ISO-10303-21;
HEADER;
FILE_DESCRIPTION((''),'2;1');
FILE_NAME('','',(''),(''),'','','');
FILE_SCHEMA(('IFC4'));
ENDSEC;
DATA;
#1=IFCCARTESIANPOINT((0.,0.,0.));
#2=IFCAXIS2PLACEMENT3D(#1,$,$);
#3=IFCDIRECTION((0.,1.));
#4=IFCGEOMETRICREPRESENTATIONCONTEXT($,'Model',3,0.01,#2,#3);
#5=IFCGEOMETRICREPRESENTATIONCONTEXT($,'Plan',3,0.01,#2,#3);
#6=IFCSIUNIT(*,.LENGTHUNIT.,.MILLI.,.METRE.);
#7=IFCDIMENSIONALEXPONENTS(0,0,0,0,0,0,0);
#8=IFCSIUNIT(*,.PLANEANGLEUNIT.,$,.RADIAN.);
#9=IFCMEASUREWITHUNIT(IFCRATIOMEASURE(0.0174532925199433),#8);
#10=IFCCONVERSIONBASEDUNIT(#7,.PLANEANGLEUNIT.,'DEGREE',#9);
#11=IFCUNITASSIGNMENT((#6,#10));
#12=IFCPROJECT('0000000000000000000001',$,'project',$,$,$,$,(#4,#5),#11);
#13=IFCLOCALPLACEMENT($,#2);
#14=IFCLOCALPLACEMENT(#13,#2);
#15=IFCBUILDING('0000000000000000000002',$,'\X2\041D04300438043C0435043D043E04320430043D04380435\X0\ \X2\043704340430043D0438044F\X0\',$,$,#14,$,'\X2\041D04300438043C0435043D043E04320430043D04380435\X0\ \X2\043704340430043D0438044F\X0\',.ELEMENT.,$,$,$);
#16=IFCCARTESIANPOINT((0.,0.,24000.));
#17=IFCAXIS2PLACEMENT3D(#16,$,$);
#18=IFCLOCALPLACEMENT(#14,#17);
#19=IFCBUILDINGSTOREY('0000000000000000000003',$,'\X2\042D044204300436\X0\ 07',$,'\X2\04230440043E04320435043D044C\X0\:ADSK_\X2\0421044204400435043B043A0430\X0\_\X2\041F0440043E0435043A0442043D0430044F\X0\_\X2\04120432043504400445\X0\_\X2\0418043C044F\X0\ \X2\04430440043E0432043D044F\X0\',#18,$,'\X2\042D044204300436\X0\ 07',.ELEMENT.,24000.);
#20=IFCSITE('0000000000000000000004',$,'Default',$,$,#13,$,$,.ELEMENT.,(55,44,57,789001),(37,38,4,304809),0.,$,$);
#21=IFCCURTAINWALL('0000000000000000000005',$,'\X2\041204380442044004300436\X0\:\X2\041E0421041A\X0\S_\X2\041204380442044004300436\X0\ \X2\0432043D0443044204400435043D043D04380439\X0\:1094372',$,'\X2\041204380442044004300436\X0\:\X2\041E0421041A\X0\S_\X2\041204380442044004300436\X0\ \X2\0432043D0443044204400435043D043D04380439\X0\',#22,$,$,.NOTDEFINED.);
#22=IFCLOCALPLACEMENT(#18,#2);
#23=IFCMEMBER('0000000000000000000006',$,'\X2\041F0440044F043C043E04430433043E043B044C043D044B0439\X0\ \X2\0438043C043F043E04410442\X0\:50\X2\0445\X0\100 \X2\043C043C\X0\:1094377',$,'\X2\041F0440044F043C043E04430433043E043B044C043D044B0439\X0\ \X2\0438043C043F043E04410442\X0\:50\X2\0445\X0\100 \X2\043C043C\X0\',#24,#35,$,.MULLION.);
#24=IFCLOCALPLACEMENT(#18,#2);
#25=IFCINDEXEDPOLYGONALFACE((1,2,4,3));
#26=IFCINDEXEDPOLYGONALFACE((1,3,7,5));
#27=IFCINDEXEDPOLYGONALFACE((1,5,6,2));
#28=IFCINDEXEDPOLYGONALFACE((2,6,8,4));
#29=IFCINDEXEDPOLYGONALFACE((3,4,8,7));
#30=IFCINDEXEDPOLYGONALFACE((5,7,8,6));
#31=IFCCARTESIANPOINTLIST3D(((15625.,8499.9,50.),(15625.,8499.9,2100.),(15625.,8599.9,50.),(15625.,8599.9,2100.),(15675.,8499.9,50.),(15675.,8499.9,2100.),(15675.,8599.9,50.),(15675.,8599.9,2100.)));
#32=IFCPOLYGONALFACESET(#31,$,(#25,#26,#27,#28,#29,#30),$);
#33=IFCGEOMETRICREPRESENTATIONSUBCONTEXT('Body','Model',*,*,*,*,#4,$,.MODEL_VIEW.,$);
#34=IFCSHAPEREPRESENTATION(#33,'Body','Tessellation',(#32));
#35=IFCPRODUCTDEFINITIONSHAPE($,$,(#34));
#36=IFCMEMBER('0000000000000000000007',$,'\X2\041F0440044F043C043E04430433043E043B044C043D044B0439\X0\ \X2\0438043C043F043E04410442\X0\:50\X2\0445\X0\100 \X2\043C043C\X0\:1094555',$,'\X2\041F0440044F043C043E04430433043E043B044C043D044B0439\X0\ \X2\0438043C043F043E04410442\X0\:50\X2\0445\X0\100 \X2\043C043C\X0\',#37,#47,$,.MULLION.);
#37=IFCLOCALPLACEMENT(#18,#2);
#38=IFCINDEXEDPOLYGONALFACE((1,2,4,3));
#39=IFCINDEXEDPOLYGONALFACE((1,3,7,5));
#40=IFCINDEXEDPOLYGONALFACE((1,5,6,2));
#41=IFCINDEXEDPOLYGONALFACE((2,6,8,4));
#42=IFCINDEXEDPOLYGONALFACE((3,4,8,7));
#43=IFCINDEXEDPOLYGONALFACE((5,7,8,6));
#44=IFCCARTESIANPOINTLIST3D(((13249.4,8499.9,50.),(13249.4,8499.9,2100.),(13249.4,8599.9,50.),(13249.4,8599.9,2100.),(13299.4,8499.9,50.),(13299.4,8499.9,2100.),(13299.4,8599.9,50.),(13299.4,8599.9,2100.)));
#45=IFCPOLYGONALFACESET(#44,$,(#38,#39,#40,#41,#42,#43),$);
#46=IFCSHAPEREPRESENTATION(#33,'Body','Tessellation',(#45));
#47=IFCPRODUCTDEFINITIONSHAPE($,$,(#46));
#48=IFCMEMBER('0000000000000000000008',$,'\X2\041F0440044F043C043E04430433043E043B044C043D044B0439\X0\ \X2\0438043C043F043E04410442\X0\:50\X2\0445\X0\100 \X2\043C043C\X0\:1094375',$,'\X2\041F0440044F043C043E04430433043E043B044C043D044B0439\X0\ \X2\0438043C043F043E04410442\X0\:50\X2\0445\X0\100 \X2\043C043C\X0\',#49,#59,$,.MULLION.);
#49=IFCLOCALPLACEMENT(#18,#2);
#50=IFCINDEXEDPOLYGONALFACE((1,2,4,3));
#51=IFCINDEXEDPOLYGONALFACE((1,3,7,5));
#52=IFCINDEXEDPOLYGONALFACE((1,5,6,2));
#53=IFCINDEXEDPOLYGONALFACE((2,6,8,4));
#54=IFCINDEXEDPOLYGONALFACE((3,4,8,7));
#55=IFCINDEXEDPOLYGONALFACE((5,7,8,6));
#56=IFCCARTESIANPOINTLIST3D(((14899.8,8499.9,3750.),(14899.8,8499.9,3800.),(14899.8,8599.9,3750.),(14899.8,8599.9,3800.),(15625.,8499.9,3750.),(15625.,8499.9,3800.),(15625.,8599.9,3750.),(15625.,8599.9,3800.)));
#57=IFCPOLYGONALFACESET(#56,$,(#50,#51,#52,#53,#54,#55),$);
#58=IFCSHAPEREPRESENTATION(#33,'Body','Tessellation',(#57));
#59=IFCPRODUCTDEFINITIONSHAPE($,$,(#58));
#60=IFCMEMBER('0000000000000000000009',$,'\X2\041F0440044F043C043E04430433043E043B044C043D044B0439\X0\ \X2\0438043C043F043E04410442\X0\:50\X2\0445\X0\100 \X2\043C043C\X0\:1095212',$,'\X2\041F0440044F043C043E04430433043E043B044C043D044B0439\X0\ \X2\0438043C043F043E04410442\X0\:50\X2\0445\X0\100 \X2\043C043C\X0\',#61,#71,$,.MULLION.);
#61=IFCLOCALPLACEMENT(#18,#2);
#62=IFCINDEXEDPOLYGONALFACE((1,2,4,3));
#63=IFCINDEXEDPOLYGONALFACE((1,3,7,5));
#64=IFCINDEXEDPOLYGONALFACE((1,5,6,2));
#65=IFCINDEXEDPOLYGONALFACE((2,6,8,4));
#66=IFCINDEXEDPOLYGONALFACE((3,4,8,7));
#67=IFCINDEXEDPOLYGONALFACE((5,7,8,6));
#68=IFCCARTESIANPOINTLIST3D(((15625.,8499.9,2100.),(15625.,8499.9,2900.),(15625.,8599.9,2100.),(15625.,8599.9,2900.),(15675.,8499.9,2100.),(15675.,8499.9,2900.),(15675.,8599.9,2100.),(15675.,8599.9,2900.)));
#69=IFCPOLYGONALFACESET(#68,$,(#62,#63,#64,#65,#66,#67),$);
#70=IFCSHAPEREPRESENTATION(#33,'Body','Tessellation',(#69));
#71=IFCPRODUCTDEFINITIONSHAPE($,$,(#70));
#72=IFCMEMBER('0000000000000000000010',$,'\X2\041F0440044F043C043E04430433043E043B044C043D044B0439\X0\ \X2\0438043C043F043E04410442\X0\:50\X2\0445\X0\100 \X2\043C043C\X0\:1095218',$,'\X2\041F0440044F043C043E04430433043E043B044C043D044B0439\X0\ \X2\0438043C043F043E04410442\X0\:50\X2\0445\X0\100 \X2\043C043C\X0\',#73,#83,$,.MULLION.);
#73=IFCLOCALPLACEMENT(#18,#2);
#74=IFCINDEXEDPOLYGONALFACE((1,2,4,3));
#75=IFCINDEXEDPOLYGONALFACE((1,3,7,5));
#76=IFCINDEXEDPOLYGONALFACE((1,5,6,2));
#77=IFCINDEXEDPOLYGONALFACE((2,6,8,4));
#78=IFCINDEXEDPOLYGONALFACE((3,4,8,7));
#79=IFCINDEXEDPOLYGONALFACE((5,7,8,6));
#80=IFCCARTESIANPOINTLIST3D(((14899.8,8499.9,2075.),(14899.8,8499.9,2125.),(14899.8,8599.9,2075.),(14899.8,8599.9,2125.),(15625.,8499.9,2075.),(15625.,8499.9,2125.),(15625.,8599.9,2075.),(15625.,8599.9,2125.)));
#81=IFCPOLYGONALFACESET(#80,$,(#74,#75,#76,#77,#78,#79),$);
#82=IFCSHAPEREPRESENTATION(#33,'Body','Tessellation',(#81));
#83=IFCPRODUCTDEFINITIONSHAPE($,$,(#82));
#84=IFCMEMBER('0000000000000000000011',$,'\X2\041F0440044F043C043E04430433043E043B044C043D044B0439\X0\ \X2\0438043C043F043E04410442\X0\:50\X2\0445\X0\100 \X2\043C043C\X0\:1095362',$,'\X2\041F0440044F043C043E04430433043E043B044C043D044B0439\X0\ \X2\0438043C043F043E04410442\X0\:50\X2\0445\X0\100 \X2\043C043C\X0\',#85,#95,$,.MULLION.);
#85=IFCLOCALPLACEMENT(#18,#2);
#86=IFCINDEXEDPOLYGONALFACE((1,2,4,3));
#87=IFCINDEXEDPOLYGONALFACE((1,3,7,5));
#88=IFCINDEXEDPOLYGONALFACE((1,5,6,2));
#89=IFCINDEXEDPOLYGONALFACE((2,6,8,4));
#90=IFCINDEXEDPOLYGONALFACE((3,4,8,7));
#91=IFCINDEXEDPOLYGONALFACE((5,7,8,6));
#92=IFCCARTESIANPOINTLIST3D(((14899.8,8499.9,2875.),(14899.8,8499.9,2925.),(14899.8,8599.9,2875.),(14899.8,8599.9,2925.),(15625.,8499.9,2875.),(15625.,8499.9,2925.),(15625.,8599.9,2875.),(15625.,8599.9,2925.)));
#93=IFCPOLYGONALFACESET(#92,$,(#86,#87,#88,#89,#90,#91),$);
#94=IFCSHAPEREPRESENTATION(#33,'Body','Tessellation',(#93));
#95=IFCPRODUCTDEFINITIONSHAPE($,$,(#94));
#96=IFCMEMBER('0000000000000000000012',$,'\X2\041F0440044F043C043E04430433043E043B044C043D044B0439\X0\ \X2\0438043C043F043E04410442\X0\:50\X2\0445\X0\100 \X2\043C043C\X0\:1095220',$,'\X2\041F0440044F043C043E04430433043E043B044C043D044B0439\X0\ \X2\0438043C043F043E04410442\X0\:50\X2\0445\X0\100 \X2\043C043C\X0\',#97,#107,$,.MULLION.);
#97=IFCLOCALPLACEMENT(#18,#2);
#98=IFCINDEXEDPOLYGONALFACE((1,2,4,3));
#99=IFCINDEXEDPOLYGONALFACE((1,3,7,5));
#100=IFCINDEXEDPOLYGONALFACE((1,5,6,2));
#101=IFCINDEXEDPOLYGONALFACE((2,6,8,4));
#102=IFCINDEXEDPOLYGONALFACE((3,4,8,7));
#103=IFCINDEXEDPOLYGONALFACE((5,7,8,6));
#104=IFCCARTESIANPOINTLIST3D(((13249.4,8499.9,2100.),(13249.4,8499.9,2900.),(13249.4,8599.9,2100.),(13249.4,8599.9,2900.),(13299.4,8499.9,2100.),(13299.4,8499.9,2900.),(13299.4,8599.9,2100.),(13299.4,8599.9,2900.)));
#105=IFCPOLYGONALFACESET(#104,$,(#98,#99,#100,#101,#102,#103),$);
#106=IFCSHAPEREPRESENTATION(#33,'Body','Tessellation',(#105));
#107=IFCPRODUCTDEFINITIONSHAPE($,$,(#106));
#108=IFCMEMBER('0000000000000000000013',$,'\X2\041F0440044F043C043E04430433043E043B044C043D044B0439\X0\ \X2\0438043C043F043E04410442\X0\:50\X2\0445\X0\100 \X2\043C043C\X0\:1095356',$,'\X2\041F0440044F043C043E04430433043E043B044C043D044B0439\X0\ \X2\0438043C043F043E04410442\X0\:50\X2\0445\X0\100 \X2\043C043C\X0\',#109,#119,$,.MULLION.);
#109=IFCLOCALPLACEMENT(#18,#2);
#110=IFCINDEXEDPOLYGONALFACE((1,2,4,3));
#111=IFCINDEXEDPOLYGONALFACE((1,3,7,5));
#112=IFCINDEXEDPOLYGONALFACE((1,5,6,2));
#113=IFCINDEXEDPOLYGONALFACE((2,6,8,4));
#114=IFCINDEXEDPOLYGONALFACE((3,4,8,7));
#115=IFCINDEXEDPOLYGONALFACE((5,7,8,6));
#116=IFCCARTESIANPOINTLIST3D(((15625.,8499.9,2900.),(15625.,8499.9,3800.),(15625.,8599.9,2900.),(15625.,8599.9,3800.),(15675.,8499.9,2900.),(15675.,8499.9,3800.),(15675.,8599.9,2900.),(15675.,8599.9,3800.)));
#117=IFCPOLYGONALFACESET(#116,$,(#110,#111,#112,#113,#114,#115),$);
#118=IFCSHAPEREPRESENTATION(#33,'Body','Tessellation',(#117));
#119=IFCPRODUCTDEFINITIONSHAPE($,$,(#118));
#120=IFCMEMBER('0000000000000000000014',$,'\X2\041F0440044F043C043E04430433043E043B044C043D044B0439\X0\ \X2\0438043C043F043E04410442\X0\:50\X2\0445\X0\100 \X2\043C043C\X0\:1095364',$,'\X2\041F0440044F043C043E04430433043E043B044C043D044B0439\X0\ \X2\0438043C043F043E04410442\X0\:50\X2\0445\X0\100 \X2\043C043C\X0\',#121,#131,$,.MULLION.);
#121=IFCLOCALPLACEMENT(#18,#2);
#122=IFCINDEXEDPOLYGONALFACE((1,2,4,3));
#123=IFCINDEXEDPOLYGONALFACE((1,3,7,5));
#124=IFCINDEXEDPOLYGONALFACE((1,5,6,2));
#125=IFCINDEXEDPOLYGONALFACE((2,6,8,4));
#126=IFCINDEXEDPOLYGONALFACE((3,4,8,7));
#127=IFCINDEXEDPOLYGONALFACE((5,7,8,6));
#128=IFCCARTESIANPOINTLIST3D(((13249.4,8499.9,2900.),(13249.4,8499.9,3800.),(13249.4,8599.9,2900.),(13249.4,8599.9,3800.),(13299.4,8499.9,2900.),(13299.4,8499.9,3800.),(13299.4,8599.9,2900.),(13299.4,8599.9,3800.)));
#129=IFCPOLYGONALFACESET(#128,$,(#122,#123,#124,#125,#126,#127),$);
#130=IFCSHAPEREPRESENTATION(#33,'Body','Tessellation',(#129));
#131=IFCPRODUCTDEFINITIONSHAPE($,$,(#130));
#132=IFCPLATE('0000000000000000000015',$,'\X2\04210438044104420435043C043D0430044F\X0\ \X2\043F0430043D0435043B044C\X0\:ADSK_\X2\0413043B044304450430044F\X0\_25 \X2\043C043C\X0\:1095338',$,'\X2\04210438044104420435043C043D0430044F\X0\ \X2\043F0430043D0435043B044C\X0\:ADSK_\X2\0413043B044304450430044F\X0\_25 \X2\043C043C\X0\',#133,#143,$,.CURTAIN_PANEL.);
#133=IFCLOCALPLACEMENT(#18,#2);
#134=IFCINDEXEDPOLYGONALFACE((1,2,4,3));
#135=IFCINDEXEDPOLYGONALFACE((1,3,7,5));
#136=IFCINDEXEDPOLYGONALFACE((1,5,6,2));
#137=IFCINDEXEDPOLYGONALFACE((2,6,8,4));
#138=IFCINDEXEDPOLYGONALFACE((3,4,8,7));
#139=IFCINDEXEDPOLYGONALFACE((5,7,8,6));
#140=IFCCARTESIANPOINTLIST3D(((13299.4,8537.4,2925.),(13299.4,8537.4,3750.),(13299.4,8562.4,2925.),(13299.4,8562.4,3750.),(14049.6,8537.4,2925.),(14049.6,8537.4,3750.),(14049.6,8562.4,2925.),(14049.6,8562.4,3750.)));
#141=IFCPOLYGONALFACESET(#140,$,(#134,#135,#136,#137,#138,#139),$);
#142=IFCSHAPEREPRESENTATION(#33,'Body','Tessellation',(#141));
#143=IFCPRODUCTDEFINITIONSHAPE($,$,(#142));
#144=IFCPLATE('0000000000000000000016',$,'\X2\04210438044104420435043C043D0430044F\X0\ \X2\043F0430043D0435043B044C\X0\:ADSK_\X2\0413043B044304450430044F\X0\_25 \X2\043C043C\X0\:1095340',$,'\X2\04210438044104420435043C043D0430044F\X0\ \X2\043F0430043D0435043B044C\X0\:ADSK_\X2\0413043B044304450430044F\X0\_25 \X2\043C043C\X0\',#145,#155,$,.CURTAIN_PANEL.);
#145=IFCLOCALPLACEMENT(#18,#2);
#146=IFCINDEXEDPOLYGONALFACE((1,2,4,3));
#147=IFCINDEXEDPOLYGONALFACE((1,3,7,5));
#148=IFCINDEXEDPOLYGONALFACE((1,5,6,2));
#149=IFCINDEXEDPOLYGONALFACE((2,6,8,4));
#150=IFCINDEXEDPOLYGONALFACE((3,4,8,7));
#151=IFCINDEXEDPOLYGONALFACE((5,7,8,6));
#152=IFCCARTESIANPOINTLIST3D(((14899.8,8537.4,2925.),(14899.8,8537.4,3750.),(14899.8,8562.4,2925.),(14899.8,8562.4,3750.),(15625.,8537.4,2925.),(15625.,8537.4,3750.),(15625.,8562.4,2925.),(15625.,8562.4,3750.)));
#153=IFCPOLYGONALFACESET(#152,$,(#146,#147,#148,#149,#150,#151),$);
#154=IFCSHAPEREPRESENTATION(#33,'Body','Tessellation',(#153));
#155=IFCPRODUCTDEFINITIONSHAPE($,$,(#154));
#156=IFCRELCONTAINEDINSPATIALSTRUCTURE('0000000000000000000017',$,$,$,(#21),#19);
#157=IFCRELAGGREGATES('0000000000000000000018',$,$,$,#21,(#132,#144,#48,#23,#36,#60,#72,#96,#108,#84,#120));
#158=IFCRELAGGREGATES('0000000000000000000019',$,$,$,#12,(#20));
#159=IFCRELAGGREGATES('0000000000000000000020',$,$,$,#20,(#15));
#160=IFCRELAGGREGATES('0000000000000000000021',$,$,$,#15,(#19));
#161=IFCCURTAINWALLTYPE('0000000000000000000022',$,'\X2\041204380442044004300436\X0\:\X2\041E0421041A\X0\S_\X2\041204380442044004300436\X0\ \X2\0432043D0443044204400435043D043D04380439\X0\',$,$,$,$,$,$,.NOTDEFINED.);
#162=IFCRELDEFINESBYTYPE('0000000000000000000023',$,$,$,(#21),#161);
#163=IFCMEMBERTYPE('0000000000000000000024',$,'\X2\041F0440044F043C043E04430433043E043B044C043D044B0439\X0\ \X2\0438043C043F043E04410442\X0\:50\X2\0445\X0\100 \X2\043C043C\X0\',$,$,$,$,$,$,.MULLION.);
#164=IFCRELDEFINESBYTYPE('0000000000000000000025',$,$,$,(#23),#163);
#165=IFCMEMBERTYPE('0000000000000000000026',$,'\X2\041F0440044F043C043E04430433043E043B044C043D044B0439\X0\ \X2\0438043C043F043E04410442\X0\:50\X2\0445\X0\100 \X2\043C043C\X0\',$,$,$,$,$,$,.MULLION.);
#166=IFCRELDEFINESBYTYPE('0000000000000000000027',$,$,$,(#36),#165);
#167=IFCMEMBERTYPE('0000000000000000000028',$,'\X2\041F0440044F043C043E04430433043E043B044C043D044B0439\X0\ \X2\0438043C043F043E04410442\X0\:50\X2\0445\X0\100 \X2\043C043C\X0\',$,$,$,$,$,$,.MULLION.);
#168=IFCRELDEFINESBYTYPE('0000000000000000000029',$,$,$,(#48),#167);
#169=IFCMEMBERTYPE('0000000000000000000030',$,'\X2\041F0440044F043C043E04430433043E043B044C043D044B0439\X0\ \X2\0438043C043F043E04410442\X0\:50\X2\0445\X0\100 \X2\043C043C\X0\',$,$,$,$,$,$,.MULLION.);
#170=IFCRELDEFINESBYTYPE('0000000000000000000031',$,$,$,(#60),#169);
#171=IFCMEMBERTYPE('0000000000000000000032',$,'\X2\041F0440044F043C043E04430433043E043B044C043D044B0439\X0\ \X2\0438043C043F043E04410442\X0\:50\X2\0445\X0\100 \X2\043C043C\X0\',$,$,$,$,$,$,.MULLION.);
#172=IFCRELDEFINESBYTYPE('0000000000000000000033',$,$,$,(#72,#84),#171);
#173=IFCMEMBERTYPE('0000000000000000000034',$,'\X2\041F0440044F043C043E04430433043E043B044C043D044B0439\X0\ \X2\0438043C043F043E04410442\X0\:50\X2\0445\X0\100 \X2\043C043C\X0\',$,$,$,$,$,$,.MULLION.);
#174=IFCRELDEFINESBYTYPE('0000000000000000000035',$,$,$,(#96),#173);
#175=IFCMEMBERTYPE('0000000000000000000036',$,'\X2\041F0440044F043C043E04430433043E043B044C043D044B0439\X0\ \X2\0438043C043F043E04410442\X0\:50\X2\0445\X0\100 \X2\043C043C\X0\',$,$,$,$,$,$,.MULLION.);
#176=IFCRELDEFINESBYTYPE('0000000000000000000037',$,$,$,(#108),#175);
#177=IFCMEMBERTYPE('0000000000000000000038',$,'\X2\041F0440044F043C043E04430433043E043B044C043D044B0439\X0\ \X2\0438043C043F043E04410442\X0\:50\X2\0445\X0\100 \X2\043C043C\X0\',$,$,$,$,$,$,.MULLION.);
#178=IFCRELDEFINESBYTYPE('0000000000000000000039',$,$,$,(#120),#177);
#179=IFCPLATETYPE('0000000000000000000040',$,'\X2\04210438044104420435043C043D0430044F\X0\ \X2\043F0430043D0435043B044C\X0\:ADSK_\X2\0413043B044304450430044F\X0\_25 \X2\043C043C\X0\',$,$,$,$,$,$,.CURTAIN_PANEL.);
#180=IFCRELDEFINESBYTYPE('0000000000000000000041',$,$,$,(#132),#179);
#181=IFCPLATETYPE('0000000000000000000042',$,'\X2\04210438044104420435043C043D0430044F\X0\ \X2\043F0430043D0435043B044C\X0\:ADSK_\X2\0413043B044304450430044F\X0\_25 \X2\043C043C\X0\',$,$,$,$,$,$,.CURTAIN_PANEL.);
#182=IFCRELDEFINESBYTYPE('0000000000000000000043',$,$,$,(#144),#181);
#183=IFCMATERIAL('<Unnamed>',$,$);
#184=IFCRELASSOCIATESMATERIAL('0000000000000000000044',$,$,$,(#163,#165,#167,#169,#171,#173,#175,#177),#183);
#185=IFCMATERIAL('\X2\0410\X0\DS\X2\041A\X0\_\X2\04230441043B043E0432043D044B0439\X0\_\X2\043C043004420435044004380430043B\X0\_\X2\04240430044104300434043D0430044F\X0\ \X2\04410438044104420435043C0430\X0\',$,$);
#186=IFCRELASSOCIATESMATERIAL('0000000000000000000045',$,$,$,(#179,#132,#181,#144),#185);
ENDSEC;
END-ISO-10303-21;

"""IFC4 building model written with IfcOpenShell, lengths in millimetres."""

from ifc_helpers import new_model, entity, si_unit, converted_unit, direction, frame, origin, place, context, subcontext, project, spatial, indexed_curve, outline, extrude, source, transform, mapped, material, type_object, type_shapes, element, aggregate, save


model = new_model("IFC4")

# Units and contexts
model_context = context("Model", 3, precision=0.01, world=origin(), true_north=direction((0.0, 1.0)))
plan_context = context("Plan", 3, precision=0.01, world=origin(), true_north=direction((0.0, 1.0)))
body_context = subcontext(model_context, "Body", "Model", "MODEL_VIEW")
ifc_project = project(units=[si_unit("LENGTHUNIT", "METRE", prefix="MILLI"), converted_unit("PLANEANGLEUNIT", "DEGREE", entity("IfcRatioMeasure", 0.0174532925199433), si_unit("PLANEANGLEUNIT", "RADIAN"), dimensions=[0, 0, 0, 0, 0, 0, 0])], contexts=[model_context, plan_context])

# Site, building, storey
site_placement = place(None, frame((0.0, 0.0, 0.0)))
site = spatial("IfcSite", under=ifc_project, at=site_placement, Name="Default", CompositionType="ELEMENT", RefLatitude=(55, 44, 57, 789001), RefLongitude=(37, 38, 4, 304809), RefElevation=0.0)
building_placement = place(site_placement, origin())
building = spatial("IfcBuilding", under=site, at=building_placement, Name="Наименование здания", LongName="Наименование здания", CompositionType="ELEMENT")
storey_placement = place(building_placement, frame((0.0, 0.0, 24000.0)))
storey = spatial("IfcBuildingStorey", under=building, at=storey_placement, Name="Этаж 07", ObjectType="Уровень:ADSK_Стрелка_Проектная_Вверх_Имя уровня", LongName="Этаж 07", CompositionType="ELEMENT", Elevation=24000.0)

# Curtain wall, members, plates
curtain_wall_type = type_object("IfcCurtainWallType", Name="Витраж:ОСКS_Витраж внутренний", PredefinedType="NOTDEFINED")
curtain_wall_placement = place(storey_placement, frame((0.0, 0.0, -24000.0)))
curtain_wall = element("IfcCurtainWall", 1, at=curtain_wall_placement, inside=storey, type_object=curtain_wall_type, Name="Витраж:ОСКS_Витраж внутренний:1094372", ObjectType="Витраж:ОСКS_Витраж внутренний", PredefinedType="NOTDEFINED")
ifc_material_1 = material(Name="<Unnamed>")
member_type_1 = type_object("IfcMemberType", Name="Прямоугольный импост:50х100 мм", PredefinedType="MULLION", material=ifc_material_1)
shared_shape_1 = source(origin(), body_context, "Body", "SweptSolid", [
    extrude(outline(indexed_curve([(-50.0, -25.0), (50.0, -25.0), (50.0, 25.0), (-50.0, 25.0), (-50.0, -25.0)], self_intersect=False)), frame((-25.0, 0.0, -2050.0), z_axis=(0.0, 0.0, 1.0), x_axis=(0.0, -1.0, 0.0)), (0.0, 0.0, 1.0), 2050.0),
])
type_shapes(member_type_1, [shared_shape_1])
member_1_placement = place(storey_placement, frame((15675.0, 8549.9, 50.0), z_axis=(0.0, 0.0, -1.0), x_axis=(1.0, 0.0, 0.0)))
member_1 = element("IfcMember", 2, at=member_1_placement, type_object=member_type_1, Name="Прямоугольный импост:50х100 мм:1094377", ObjectType="Прямоугольный импост:50х100 мм", PredefinedType="MULLION", context=body_context, shape_type="MappedRepresentation", body=[
    mapped(shared_shape_1, transform((0.0, 0.0, 0.0), scale=1.0)),
])
member_type_2 = type_object("IfcMemberType", Name="Прямоугольный импост:50х100 мм", PredefinedType="MULLION", material=ifc_material_1)
shared_shape_2 = source(origin(), body_context, "Body", "SweptSolid", [
    extrude(outline(indexed_curve([(-50.0, -25.0), (50.0, -25.0), (50.0, 25.0), (-50.0, 25.0), (-50.0, -25.0)], self_intersect=False)), frame((0.0, 0.0, -2050.0), z_axis=(0.0, 0.0, 1.0), x_axis=(0.0, -1.0, 0.0)), (0.0, 0.0, 1.0), 2050.0),
])
type_shapes(member_type_2, [shared_shape_2])
member_2_placement = place(storey_placement, frame((13274.4, 8549.9, 50.0), z_axis=(0.0, 0.0, -1.0), x_axis=(1.0, 0.0, 0.0)))
member_2 = element("IfcMember", 3, at=member_2_placement, type_object=member_type_2, Name="Прямоугольный импост:50х100 мм:1094555", ObjectType="Прямоугольный импост:50х100 мм", PredefinedType="MULLION", context=body_context, shape_type="MappedRepresentation", body=[
    mapped(shared_shape_2, transform((0.0, 0.0, 0.0), scale=1.0)),
])
member_type_3 = type_object("IfcMemberType", Name="Прямоугольный импост:50х100 мм", PredefinedType="MULLION", material=ifc_material_1)
shared_shape_3 = source(origin(), body_context, "Body", "SweptSolid", [
    extrude(outline(indexed_curve([(-50.0, -25.0), (50.0, -25.0), (50.0, 25.0), (-50.0, 25.0), (-50.0, -25.0)], self_intersect=False)), frame((-25.0, 0.0, -725.2), z_axis=(0.0, 0.0, 1.0), x_axis=(0.0, -1.0, 0.0)), (0.0, 0.0, 1.0), 725.2),
])
type_shapes(member_type_3, [shared_shape_3])
member_3_placement = place(storey_placement, frame((15625.0, 8549.9, 3800.0), z_axis=(1.0, 0.0, 0.0), x_axis=(0.0, 0.0, 1.0)))
member_3 = element("IfcMember", 4, at=member_3_placement, type_object=member_type_3, Name="Прямоугольный импост:50х100 мм:1094375", ObjectType="Прямоугольный импост:50х100 мм", PredefinedType="MULLION", context=body_context, shape_type="MappedRepresentation", body=[
    mapped(shared_shape_3, transform((0.0, 0.0, 0.0), scale=1.0)),
])
member_type_4 = type_object("IfcMemberType", Name="Прямоугольный импост:50х100 мм", PredefinedType="MULLION", material=ifc_material_1)
shared_shape_4 = source(origin(), body_context, "Body", "SweptSolid", [
    extrude(outline(indexed_curve([(-50.0, -25.0), (50.0, -25.0), (50.0, 25.0), (-50.0, 25.0), (-50.0, -25.0)], self_intersect=False)), frame((-25.0, 0.0, -800.0), z_axis=(0.0, 0.0, 1.0), x_axis=(0.0, -1.0, 0.0)), (0.0, 0.0, 1.0), 800.0),
])
type_shapes(member_type_4, [shared_shape_4])
member_4_placement = place(storey_placement, frame((15675.0, 8549.9, 2100.0), z_axis=(0.0, 0.0, -1.0), x_axis=(1.0, 0.0, 0.0)))
member_4 = element("IfcMember", 5, at=member_4_placement, type_object=member_type_4, Name="Прямоугольный импост:50х100 мм:1095212", ObjectType="Прямоугольный импост:50х100 мм", PredefinedType="MULLION", context=body_context, shape_type="MappedRepresentation", body=[
    mapped(shared_shape_4, transform((0.0, 0.0, 0.0), scale=1.0)),
])
member_type_5 = type_object("IfcMemberType", Name="Прямоугольный импост:50х100 мм", PredefinedType="MULLION", material=ifc_material_1)
shared_shape_5 = source(origin(), body_context, "Body", "SweptSolid", [
    extrude(outline(indexed_curve([(-50.0, -25.0), (50.0, -25.0), (50.0, 25.0), (-50.0, 25.0), (-50.0, -25.0)], self_intersect=False)), frame((0.0, 0.0, -725.2), z_axis=(0.0, 0.0, 1.0), x_axis=(0.0, -1.0, 0.0)), (0.0, 0.0, 1.0), 725.2),
])
type_shapes(member_type_5, [shared_shape_5])
member_5_placement = place(storey_placement, frame((15625.0, 8549.9, 2100.0), z_axis=(1.0, 0.0, 0.0), x_axis=(0.0, 0.0, 1.0)))
member_5 = element("IfcMember", 6, at=member_5_placement, type_object=member_type_5, Name="Прямоугольный импост:50х100 мм:1095218", ObjectType="Прямоугольный импост:50х100 мм", PredefinedType="MULLION", context=body_context, shape_type="MappedRepresentation", body=[
    mapped(shared_shape_5, transform((0.0, 0.0, 0.0), scale=1.0)),
])
member_6_placement = place(storey_placement, frame((15625.0, 8549.9, 2900.0), z_axis=(1.0, 0.0, 0.0), x_axis=(0.0, 0.0, 1.0)))
member_6 = element("IfcMember", 7, at=member_6_placement, type_object=member_type_5, Name="Прямоугольный импост:50х100 мм:1095362", ObjectType="Прямоугольный импост:50х100 мм", PredefinedType="MULLION", context=body_context, shape_type="MappedRepresentation", body=[
    mapped(shared_shape_5, transform((0.0, 0.0, 0.0), scale=1.0)),
])
member_type_6 = type_object("IfcMemberType", Name="Прямоугольный импост:50х100 мм", PredefinedType="MULLION", material=ifc_material_1)
shared_shape_6 = source(origin(), body_context, "Body", "SweptSolid", [
    extrude(outline(indexed_curve([(-50.0, -25.0), (50.0, -25.0), (50.0, 25.0), (-50.0, 25.0), (-50.0, -25.0)], self_intersect=False)), frame((0.0, 0.0, -800.0), z_axis=(0.0, 0.0, 1.0), x_axis=(0.0, -1.0, 0.0)), (0.0, 0.0, 1.0), 800.0),
])
type_shapes(member_type_6, [shared_shape_6])
member_7_placement = place(storey_placement, frame((13274.4, 8549.9, 2100.0), z_axis=(0.0, 0.0, -1.0), x_axis=(1.0, 0.0, 0.0)))
member_7 = element("IfcMember", 8, at=member_7_placement, type_object=member_type_6, Name="Прямоугольный импост:50х100 мм:1095220", ObjectType="Прямоугольный импост:50х100 мм", PredefinedType="MULLION", context=body_context, shape_type="MappedRepresentation", body=[
    mapped(shared_shape_6, transform((0.0, 0.0, 0.0), scale=1.0)),
])
member_type_7 = type_object("IfcMemberType", Name="Прямоугольный импост:50х100 мм", PredefinedType="MULLION", material=ifc_material_1)
shared_shape_7 = source(origin(), body_context, "Body", "SweptSolid", [
    extrude(outline(indexed_curve([(-50.0, -25.0), (50.0, -25.0), (50.0, 25.0), (-50.0, 25.0), (-50.0, -25.0)], self_intersect=False)), frame((-25.0, 0.0, -900.0), z_axis=(0.0, 0.0, 1.0), x_axis=(0.0, -1.0, 0.0)), (0.0, 0.0, 1.0), 900.0),
])
type_shapes(member_type_7, [shared_shape_7])
member_8_placement = place(storey_placement, frame((15675.0, 8549.9, 2900.0), z_axis=(0.0, 0.0, -1.0), x_axis=(1.0, 0.0, 0.0)))
member_8 = element("IfcMember", 9, at=member_8_placement, type_object=member_type_7, Name="Прямоугольный импост:50х100 мм:1095356", ObjectType="Прямоугольный импост:50х100 мм", PredefinedType="MULLION", context=body_context, shape_type="MappedRepresentation", body=[
    mapped(shared_shape_7, transform((0.0, 0.0, 0.0), scale=1.0)),
])
member_type_8 = type_object("IfcMemberType", Name="Прямоугольный импост:50х100 мм", PredefinedType="MULLION", material=ifc_material_1)
shared_shape_8 = source(origin(), body_context, "Body", "SweptSolid", [
    extrude(outline(indexed_curve([(-50.0, -25.0), (50.0, -25.0), (50.0, 25.0), (-50.0, 25.0), (-50.0, -25.0)], self_intersect=False)), frame((0.0, 0.0, -900.0), z_axis=(0.0, 0.0, 1.0), x_axis=(0.0, -1.0, 0.0)), (0.0, 0.0, 1.0), 900.0),
])
type_shapes(member_type_8, [shared_shape_8])
member_9_placement = place(storey_placement, frame((13274.4, 8549.9, 2900.0), z_axis=(0.0, 0.0, -1.0), x_axis=(1.0, 0.0, 0.0)))
member_9 = element("IfcMember", 10, at=member_9_placement, type_object=member_type_8, Name="Прямоугольный импост:50х100 мм:1095364", ObjectType="Прямоугольный импост:50х100 мм", PredefinedType="MULLION", context=body_context, shape_type="MappedRepresentation", body=[
    mapped(shared_shape_8, transform((0.0, 0.0, 0.0), scale=1.0)),
])
ifc_material_2 = material(Name="АDSК_Условный_материал_Фасадная система")
plate_type_1 = type_object("IfcPlateType", Name="Системная панель:ADSK_Глухая_25 мм", PredefinedType="CURTAIN_PANEL", material=ifc_material_2)
shared_shape_9 = source(origin(), body_context, "Body", "SweptSolid", [
    extrude(outline(indexed_curve([(-12.5, -375.1), (12.5, -375.1), (12.5, 375.1), (-12.5, 375.1), (-12.5, -375.1)], self_intersect=False)), frame((0.0, 0.0, 0.0), z_axis=(0.0, 0.0, 1.0), x_axis=(0.0, 1.0, 0.0)), (0.0, 0.0, 1.0), 825.0),
])
type_shapes(plate_type_1, [shared_shape_9])
plate_1_placement = place(curtain_wall_placement, frame((13674.5, 8549.9, 26925.0)))
plate_1 = element("IfcPlate", 11, at=plate_1_placement, type_object=plate_type_1, material=ifc_material_2, Name="Системная панель:ADSK_Глухая_25 мм:1095338", ObjectType="Системная панель:ADSK_Глухая_25 мм", PredefinedType="CURTAIN_PANEL", context=body_context, shape_type="MappedRepresentation", body=[
    mapped(shared_shape_9, transform((0.0, 0.0, 0.0), scale=1.0)),
])
plate_type_2 = type_object("IfcPlateType", Name="Системная панель:ADSK_Глухая_25 мм", PredefinedType="CURTAIN_PANEL", material=ifc_material_2)
shared_shape_10 = source(origin(), body_context, "Body", "SweptSolid", [
    extrude(outline(indexed_curve([(-12.5, -362.6), (12.5, -362.6), (12.5, 362.6), (-12.5, 362.6), (-12.5, -362.6)], self_intersect=False)), frame((0.0, 0.0, 0.0), z_axis=(0.0, 0.0, 1.0), x_axis=(0.0, 1.0, 0.0)), (0.0, 0.0, 1.0), 825.0),
])
type_shapes(plate_type_2, [shared_shape_10])
plate_2_placement = place(curtain_wall_placement, frame((15262.4, 8549.9, 26925.0)))
plate_2 = element("IfcPlate", 12, at=plate_2_placement, type_object=plate_type_2, material=ifc_material_2, Name="Системная панель:ADSK_Глухая_25 мм:1095340", ObjectType="Системная панель:ADSK_Глухая_25 мм", PredefinedType="CURTAIN_PANEL", context=body_context, shape_type="MappedRepresentation", body=[
    mapped(shared_shape_10, transform((0.0, 0.0, 0.0), scale=1.0)),
])

aggregate(curtain_wall, [plate_1, plate_2, member_3, member_1, member_2, member_4, member_5, member_7, member_8, member_6, member_9])

save(model, "model.ifc")
